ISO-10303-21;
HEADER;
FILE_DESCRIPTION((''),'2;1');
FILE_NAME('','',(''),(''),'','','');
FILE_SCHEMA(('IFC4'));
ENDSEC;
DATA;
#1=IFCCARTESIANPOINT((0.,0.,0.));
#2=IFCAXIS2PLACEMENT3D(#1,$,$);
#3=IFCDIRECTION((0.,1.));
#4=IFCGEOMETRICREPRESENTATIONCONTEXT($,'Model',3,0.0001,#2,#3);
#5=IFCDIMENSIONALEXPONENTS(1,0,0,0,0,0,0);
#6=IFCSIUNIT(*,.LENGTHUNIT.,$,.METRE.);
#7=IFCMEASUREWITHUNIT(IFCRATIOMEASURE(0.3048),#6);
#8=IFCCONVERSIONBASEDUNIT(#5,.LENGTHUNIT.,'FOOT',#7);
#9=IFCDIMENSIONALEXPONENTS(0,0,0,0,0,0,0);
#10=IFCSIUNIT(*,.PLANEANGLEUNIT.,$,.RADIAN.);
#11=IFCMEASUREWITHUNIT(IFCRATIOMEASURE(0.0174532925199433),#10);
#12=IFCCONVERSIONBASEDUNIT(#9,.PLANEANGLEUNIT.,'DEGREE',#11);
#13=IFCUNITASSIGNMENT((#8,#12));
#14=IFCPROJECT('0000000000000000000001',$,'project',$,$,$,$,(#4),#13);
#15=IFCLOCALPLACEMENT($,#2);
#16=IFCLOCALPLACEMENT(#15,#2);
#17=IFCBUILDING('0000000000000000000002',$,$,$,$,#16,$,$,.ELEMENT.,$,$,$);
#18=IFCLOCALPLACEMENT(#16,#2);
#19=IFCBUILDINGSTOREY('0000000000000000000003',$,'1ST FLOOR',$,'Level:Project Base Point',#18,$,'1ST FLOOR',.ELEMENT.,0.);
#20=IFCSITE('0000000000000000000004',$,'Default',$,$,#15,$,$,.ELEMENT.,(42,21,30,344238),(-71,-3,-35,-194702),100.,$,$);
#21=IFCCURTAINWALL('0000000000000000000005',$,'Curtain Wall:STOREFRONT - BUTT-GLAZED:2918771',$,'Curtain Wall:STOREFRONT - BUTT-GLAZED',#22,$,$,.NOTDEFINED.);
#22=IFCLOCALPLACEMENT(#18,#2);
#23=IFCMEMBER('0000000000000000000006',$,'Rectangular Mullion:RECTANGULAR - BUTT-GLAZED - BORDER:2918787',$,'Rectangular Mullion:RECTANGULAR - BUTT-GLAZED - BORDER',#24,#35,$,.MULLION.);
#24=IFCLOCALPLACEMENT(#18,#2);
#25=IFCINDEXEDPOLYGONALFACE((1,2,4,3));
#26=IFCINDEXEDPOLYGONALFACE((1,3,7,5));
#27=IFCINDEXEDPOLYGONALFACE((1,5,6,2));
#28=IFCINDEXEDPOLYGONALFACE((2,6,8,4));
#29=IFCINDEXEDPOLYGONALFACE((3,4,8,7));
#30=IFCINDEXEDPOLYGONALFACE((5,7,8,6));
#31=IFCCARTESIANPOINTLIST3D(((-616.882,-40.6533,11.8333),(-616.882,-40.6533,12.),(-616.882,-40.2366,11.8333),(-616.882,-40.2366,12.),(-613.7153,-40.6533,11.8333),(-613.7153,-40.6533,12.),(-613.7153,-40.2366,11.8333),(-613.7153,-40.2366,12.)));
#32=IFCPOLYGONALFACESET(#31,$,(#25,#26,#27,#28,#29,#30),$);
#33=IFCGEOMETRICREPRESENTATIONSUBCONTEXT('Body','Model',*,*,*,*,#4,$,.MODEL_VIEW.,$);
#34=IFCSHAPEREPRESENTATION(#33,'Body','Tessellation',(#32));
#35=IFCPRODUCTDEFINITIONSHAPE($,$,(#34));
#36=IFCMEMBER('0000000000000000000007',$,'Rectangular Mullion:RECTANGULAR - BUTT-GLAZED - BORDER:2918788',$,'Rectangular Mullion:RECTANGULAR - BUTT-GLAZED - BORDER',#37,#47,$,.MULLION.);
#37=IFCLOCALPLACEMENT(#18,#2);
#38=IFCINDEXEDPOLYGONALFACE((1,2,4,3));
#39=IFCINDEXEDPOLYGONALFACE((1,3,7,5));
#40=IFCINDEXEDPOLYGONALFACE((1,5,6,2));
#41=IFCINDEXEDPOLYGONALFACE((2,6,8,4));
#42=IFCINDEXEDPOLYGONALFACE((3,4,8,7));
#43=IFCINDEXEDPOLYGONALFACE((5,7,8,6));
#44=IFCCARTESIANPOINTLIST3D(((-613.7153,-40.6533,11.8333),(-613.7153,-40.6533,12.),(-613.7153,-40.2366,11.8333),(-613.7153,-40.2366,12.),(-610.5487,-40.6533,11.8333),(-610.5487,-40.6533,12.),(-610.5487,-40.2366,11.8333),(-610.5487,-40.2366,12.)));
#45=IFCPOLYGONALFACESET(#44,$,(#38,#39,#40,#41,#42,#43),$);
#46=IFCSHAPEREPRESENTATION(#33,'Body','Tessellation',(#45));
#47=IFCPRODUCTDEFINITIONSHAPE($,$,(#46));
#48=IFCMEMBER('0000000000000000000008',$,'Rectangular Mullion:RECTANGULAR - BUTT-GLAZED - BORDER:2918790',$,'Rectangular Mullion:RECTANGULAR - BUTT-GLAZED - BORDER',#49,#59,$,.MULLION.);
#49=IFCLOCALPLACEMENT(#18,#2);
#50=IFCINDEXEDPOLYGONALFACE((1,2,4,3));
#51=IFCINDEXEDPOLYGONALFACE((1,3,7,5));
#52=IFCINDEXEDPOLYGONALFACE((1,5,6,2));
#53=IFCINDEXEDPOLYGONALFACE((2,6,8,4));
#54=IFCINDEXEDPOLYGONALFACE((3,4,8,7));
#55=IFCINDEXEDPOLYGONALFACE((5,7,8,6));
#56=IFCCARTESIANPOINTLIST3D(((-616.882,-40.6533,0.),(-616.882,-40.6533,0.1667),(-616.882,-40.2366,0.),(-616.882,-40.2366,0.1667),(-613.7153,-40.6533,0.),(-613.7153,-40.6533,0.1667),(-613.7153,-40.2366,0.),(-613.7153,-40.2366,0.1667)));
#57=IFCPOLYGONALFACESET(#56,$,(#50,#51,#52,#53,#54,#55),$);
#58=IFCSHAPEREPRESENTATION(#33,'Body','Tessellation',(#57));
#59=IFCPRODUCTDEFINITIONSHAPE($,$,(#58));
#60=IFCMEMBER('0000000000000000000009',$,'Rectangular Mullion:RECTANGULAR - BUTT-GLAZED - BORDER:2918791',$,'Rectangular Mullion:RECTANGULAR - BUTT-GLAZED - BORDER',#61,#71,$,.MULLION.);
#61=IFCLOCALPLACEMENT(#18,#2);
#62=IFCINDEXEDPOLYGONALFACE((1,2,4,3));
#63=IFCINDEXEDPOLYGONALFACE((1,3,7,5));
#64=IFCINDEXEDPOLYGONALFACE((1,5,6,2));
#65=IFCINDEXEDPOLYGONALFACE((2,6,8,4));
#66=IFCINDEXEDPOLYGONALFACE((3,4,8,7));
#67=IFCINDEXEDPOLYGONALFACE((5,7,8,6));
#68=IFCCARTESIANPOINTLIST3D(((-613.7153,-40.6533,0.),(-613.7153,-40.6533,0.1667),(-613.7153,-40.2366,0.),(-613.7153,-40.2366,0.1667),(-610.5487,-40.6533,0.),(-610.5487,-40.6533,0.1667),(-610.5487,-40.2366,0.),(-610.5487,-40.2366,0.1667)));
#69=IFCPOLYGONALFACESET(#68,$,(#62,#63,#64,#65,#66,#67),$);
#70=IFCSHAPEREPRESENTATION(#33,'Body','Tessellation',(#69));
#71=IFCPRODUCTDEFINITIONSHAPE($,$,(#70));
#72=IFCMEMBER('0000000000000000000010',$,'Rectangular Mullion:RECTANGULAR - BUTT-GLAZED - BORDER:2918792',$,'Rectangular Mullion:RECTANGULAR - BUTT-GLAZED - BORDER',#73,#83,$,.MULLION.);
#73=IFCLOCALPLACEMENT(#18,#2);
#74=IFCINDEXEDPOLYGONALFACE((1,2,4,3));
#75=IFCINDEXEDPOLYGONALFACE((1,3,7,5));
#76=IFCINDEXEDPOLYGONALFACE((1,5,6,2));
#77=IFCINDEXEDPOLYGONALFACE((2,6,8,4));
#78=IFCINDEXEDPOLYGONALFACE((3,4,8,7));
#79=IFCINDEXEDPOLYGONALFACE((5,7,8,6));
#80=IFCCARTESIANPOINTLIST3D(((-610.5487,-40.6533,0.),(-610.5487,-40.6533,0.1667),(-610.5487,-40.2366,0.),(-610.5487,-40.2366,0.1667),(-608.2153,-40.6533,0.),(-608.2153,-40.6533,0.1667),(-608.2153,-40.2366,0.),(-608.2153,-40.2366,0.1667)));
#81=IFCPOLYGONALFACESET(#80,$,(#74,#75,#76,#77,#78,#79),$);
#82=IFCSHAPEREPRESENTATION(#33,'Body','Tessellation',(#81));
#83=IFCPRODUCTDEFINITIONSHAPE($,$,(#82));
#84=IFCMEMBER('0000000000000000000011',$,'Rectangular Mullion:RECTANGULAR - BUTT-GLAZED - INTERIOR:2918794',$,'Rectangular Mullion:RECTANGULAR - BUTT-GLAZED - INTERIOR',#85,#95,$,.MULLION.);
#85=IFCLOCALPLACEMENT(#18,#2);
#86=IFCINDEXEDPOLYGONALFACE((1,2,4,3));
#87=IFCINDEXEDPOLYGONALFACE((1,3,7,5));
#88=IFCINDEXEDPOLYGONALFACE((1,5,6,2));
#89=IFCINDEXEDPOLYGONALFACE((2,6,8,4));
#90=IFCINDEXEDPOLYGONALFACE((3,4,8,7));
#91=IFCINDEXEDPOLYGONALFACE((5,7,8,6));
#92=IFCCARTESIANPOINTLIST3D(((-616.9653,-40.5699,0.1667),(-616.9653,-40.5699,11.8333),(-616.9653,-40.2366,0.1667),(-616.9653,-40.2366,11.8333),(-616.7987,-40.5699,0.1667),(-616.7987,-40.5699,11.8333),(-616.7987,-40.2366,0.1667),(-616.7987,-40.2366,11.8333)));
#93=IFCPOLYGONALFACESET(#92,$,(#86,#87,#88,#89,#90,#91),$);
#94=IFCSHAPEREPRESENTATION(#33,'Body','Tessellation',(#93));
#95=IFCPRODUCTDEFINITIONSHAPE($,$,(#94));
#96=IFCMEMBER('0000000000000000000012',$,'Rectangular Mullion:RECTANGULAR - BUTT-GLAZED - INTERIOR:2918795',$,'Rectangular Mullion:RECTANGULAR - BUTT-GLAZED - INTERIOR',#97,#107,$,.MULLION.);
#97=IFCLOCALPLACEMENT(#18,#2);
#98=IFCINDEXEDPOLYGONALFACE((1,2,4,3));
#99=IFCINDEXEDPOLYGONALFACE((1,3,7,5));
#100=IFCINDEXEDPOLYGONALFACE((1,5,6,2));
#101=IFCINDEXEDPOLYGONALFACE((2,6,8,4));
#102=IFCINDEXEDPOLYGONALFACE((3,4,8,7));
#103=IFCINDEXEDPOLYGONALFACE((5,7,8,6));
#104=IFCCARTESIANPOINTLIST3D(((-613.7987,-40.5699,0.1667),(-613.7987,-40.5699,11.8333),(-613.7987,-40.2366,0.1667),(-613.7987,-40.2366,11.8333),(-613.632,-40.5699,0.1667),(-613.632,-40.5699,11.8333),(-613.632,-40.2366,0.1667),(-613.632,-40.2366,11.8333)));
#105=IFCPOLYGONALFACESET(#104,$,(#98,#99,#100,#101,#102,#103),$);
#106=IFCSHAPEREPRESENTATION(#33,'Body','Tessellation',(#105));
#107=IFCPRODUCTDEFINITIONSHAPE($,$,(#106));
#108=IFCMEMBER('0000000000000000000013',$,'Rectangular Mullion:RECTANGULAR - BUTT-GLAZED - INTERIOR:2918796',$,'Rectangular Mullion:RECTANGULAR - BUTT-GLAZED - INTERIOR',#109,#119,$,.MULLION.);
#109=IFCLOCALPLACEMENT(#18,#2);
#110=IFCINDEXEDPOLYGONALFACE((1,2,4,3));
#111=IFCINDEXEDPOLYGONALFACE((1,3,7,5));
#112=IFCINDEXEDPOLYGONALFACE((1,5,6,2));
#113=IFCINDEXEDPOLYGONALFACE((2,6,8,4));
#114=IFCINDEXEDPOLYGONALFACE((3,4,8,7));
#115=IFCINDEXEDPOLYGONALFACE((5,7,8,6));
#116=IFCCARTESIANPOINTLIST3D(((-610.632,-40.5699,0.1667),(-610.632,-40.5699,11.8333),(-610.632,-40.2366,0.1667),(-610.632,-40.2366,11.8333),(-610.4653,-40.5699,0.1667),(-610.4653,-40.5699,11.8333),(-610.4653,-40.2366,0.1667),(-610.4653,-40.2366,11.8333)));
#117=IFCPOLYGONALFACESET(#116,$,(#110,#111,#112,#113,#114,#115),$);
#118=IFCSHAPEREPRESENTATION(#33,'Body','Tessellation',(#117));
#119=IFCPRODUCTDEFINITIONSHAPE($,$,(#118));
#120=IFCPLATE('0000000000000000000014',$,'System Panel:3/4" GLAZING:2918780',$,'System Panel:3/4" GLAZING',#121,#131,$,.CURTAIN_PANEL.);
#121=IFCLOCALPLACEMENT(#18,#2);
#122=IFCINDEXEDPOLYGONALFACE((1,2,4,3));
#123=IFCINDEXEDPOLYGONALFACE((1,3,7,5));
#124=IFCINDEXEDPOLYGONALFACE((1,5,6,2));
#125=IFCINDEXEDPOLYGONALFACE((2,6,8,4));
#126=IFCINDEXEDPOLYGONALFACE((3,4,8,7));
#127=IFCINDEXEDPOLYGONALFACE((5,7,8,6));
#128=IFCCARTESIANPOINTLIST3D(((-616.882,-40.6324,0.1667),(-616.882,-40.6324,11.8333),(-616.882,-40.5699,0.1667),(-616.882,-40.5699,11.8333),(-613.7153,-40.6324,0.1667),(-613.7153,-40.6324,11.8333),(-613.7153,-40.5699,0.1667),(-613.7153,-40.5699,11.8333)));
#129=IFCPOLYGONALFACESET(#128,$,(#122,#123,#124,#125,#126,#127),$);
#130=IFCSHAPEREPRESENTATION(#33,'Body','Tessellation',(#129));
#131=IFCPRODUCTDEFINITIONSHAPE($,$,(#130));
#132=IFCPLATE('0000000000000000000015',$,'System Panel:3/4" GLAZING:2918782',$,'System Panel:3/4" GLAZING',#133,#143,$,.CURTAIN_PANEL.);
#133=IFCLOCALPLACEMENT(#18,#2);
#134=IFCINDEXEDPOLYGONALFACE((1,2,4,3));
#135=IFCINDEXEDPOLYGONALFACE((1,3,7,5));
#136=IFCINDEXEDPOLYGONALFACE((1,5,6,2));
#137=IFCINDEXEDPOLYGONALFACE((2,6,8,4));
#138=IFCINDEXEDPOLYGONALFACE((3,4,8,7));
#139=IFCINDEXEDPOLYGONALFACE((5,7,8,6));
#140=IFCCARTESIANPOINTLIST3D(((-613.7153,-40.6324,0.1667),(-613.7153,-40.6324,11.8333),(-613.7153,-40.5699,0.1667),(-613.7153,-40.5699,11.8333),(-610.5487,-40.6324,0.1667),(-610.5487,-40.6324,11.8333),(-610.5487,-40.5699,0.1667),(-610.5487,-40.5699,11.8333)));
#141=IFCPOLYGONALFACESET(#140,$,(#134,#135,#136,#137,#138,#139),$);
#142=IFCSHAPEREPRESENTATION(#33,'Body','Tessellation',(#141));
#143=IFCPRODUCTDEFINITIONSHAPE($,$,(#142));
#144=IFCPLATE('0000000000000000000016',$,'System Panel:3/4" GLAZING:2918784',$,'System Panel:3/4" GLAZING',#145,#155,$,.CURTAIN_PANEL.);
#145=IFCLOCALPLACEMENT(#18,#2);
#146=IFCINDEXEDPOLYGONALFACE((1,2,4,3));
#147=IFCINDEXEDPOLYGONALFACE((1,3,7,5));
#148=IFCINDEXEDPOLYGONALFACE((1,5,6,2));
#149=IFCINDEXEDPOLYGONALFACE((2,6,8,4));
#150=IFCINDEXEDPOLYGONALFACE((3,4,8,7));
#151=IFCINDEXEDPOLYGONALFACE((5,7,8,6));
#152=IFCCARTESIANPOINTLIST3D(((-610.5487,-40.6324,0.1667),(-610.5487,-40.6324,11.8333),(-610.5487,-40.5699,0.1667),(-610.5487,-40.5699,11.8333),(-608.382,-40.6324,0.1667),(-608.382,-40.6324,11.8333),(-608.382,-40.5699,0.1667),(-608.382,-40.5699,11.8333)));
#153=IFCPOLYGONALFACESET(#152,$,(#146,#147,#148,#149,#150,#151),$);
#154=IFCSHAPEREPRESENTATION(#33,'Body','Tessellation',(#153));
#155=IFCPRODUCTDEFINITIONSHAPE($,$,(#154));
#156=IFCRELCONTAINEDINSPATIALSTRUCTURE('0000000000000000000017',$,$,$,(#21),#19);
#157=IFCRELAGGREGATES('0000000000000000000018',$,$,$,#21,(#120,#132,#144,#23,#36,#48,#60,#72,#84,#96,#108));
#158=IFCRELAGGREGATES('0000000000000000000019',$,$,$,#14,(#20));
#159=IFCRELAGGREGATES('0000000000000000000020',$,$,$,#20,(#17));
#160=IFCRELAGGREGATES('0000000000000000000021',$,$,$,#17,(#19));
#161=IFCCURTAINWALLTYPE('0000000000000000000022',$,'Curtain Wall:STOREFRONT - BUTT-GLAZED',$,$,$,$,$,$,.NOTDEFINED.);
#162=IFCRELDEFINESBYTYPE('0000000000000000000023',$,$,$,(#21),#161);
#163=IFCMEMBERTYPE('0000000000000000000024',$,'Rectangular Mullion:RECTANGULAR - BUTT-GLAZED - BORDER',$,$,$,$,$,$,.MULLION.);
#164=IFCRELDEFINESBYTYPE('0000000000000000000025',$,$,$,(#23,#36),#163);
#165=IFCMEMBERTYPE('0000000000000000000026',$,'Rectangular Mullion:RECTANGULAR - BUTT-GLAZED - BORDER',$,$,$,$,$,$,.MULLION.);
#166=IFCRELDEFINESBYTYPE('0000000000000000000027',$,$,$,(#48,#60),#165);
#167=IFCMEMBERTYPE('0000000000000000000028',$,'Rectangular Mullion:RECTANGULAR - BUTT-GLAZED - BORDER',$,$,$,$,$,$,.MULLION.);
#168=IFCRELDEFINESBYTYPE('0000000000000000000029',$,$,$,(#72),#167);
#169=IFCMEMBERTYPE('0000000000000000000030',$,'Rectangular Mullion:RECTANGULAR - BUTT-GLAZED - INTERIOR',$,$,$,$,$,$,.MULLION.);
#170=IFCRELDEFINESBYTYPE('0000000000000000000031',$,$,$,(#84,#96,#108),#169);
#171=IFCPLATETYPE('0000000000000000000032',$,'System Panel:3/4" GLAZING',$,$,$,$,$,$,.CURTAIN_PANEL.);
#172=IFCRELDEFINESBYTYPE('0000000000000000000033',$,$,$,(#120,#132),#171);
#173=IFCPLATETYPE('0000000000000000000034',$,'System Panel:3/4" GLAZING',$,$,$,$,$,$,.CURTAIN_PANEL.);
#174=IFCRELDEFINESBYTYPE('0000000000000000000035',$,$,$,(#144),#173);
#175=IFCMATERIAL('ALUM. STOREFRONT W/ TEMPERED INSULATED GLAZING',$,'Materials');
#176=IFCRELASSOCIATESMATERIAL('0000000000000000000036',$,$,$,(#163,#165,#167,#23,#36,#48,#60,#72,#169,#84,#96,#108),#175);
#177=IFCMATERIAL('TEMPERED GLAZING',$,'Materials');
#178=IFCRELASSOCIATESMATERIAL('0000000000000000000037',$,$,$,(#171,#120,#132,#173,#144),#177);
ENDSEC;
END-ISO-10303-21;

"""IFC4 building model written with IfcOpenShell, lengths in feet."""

from ifc_helpers import new_model, entity, si_unit, converted_unit, direction, frame, frame_2d, origin, origin_2d_with_axis, place, context, subcontext, project, spatial, rectangle, extrude, source, transform, mapped, material, material_profile, profile_set, profile_usage, type_object, type_shapes, element, aggregate, save


model = new_model("IFC4")

# Units and contexts
model_context = context("Model", 3, precision=0.0001, world=origin(), true_north=direction((0.0, 1.0)))
body_context = subcontext(model_context, "Body", "Model", "MODEL_VIEW")
ifc_project = project(units=[converted_unit("LENGTHUNIT", "FOOT", entity("IfcRatioMeasure", 0.3048), si_unit("LENGTHUNIT", "METRE"), dimensions=[1, 0, 0, 0, 0, 0, 0]), converted_unit("PLANEANGLEUNIT", "DEGREE", entity("IfcRatioMeasure", 0.0174532925199433), si_unit("PLANEANGLEUNIT", "RADIAN"), dimensions=[0, 0, 0, 0, 0, 0, 0])], contexts=[model_context])

# Site, building, storey
site_placement = place(None, origin())
site = spatial("IfcSite", under=ifc_project, at=site_placement, Name="Default", CompositionType="ELEMENT", RefLatitude=(42, 21, 30, 344238), RefLongitude=(-71, -3, -35, -194702), RefElevation=100.0)
building_placement = place(site_placement, origin())
building = spatial("IfcBuilding", under=site, at=building_placement, CompositionType="ELEMENT")
storey_placement = place(building_placement, origin())
storey = spatial("IfcBuildingStorey", under=building, at=storey_placement, Name="1ST FLOOR", ObjectType="Level:Project Base Point", LongName="1ST FLOOR", CompositionType="ELEMENT", Elevation=0.0)

# Shared definitions
ifc_material_1 = material(Name="ALUM. STOREFRONT W/ TEMPERED INSULATED GLAZING", Category="Materials")

# Curtain wall, members, plates
curtain_wall_type_1 = type_object("IfcCurtainWallType", Name="Curtain Wall:STOREFRONT - BUTT-GLAZED", PredefinedType="NOTDEFINED")
curtain_wall_1_placement = place(storey_placement, origin())
curtain_wall_1 = element("IfcCurtainWall", 1, at=curtain_wall_1_placement, inside=storey, type_object=curtain_wall_type_1, Name="Curtain Wall:STOREFRONT - BUTT-GLAZED:2918771", ObjectType="Curtain Wall:STOREFRONT - BUTT-GLAZED", PredefinedType="NOTDEFINED")
ifc_material_profile_1 = material_profile(ifc_material_1, rectangle(XDim=0.4167, YDim=0.1667, at=frame_2d((0.0, 0.0), x_axis=(1.0, 0.0))), Name="RECTANGULAR - BUTT-GLAZED - BORDER")
ifc_profile_set_1 = profile_set([ifc_material_profile_1], Name="RECTANGULAR - BUTT-GLAZED - BORDER")
member_type_1 = type_object("IfcMemberType", Name="Rectangular Mullion:RECTANGULAR - BUTT-GLAZED - BORDER", PredefinedType="MULLION", material=ifc_profile_set_1)
shared_shape_1 = source(origin(), body_context, "Body", "SweptSolid", [
    extrude(rectangle(XDim=0.4167, YDim=0.1667, at=frame_2d((0.0, 0.0), x_axis=(1.0, 0.0))), frame((-0.0833, -0.1562, -3.1667), z_axis=(0.0, 0.0, 1.0), x_axis=(0.0, -1.0, 0.0)), (0.0, 0.0, 1.0), 3.1667),
])
type_shapes(member_type_1, [shared_shape_1])
ifc_profile_usage_1 = profile_usage(ifc_profile_set_1)
member_1_placement = place(storey_placement, frame((-613.7153, -40.6012, 12.0), z_axis=(1.0, 0.0, 0.0), x_axis=(0.0, 0.0, 1.0)))
member_1 = element("IfcMember", 2, at=member_1_placement, type_object=member_type_1, material=ifc_profile_usage_1, Name="Rectangular Mullion:RECTANGULAR - BUTT-GLAZED - BORDER:2918787", ObjectType="Rectangular Mullion:RECTANGULAR - BUTT-GLAZED - BORDER", PredefinedType="MULLION", context=body_context, shape_type="MappedRepresentation", body=[
    mapped(shared_shape_1, transform((0.0, 0.0, 0.0), scale=1.0)),
])
ifc_profile_usage_2 = profile_usage(ifc_profile_set_1)
member_2_placement = place(storey_placement, frame((-610.5487, -40.6012, 12.0), z_axis=(1.0, 0.0, 0.0), x_axis=(0.0, 0.0, 1.0)))
member_2 = element("IfcMember", 3, at=member_2_placement, type_object=member_type_1, material=ifc_profile_usage_2, Name="Rectangular Mullion:RECTANGULAR - BUTT-GLAZED - BORDER:2918788", ObjectType="Rectangular Mullion:RECTANGULAR - BUTT-GLAZED - BORDER", PredefinedType="MULLION", context=body_context, shape_type="MappedRepresentation", body=[
    mapped(shared_shape_1, transform((0.0, 0.0, 0.0), scale=1.0)),
])
ifc_profile_usage_3 = profile_usage(ifc_profile_set_1)
member_type_2 = type_object("IfcMemberType", Name="Rectangular Mullion:RECTANGULAR - BUTT-GLAZED - BORDER", PredefinedType="MULLION", material=ifc_profile_set_1)
shared_shape_2 = source(origin(), body_context, "Body", "SweptSolid", [
    extrude(rectangle(XDim=0.4167, YDim=0.1667, at=frame_2d((0.0, 0.0), x_axis=(1.0, 0.0))), frame((-0.0833, -0.1562, -3.1667), z_axis=(0.0, 0.0, 1.0), x_axis=(0.0, -1.0, 0.0)), (0.0, 0.0, 1.0), 3.1667),
])
type_shapes(member_type_2, [shared_shape_2])
member_3_placement = place(storey_placement, frame((-616.882, -40.6012, 0.0), z_axis=(-1.0, 0.0, 0.0), x_axis=(0.0, 0.0, -1.0)))
member_3 = element("IfcMember", 4, at=member_3_placement, type_object=member_type_2, material=ifc_profile_usage_3, Name="Rectangular Mullion:RECTANGULAR - BUTT-GLAZED - BORDER:2918790", ObjectType="Rectangular Mullion:RECTANGULAR - BUTT-GLAZED - BORDER", PredefinedType="MULLION", context=body_context, shape_type="MappedRepresentation", body=[
    mapped(shared_shape_2, transform((0.0, 0.0, 0.0), scale=1.0)),
])
ifc_profile_usage_4 = profile_usage(ifc_profile_set_1)
member_4_placement = place(storey_placement, frame((-613.7153, -40.6012, 0.0), z_axis=(-1.0, 0.0, 0.0), x_axis=(0.0, 0.0, -1.0)))
member_4 = element("IfcMember", 5, at=member_4_placement, type_object=member_type_2, material=ifc_profile_usage_4, Name="Rectangular Mullion:RECTANGULAR - BUTT-GLAZED - BORDER:2918791", ObjectType="Rectangular Mullion:RECTANGULAR - BUTT-GLAZED - BORDER", PredefinedType="MULLION", context=body_context, shape_type="MappedRepresentation", body=[
    mapped(shared_shape_2, transform((0.0, 0.0, 0.0), scale=1.0)),
])
ifc_profile_usage_5 = profile_usage(ifc_profile_set_1)
member_type_3 = type_object("IfcMemberType", Name="Rectangular Mullion:RECTANGULAR - BUTT-GLAZED - BORDER", PredefinedType="MULLION", material=ifc_profile_set_1)
shared_shape_3 = source(origin(), body_context, "Body", "SweptSolid", [
    extrude(rectangle(XDim=0.4167, YDim=0.1667, at=frame_2d((0.0, 0.0), x_axis=(1.0, 0.0))), frame((-0.0833, -0.1562, -2.3333), z_axis=(0.0, 0.0, 1.0), x_axis=(0.0, -1.0, 0.0)), (0.0, 0.0, 1.0), 2.3333),
])
type_shapes(member_type_3, [shared_shape_3])
member_5_placement = place(storey_placement, frame((-610.5487, -40.6012, 0.0), z_axis=(-1.0, 0.0, 0.0), x_axis=(0.0, 0.0, -1.0)))
member_5 = element("IfcMember", 6, at=member_5_placement, type_object=member_type_3, material=ifc_profile_usage_5, Name="Rectangular Mullion:RECTANGULAR - BUTT-GLAZED - BORDER:2918792", ObjectType="Rectangular Mullion:RECTANGULAR - BUTT-GLAZED - BORDER", PredefinedType="MULLION", context=body_context, shape_type="MappedRepresentation", body=[
    mapped(shared_shape_3, transform((0.0, 0.0, 0.0), scale=1.0)),
])
ifc_material_profile_2 = material_profile(ifc_material_1, rectangle(XDim=0.3333, YDim=0.1667, at=origin_2d_with_axis()), Name="RECTANGULAR - BUTT-GLAZED - INTERIOR")
ifc_profile_set_2 = profile_set([ifc_material_profile_2], Name="RECTANGULAR - BUTT-GLAZED - INTERIOR")
ifc_profile_usage_6 = profile_usage(ifc_profile_set_2)
member_type_4 = type_object("IfcMemberType", Name="Rectangular Mullion:RECTANGULAR - BUTT-GLAZED - INTERIOR", PredefinedType="MULLION", material=ifc_profile_set_2)
shared_shape_4 = source(origin(), body_context, "Body", "SweptSolid", [
    extrude(rectangle(XDim=0.3333, YDim=0.1667, at=origin_2d_with_axis()), frame((0.0, -0.1979, -11.6667), z_axis=(0.0, 0.0, 1.0), x_axis=(0.0, -1.0, 0.0)), (0.0, 0.0, 1.0), 11.6667),
])
type_shapes(member_type_4, [shared_shape_4])
member_6_placement = place(storey_placement, frame((-616.882, -40.6012, 0.1667), z_axis=(0.0, 0.0, -1.0), x_axis=(1.0, 0.0, 0.0)))
member_6 = element("IfcMember", 7, at=member_6_placement, type_object=member_type_4, material=ifc_profile_usage_6, Name="Rectangular Mullion:RECTANGULAR - BUTT-GLAZED - INTERIOR:2918794", ObjectType="Rectangular Mullion:RECTANGULAR - BUTT-GLAZED - INTERIOR", PredefinedType="MULLION", context=body_context, shape_type="MappedRepresentation", body=[
    mapped(shared_shape_4, transform((0.0, 0.0, 0.0), scale=1.0)),
])
ifc_profile_usage_7 = profile_usage(ifc_profile_set_2)
member_7_placement = place(storey_placement, frame((-613.7153, -40.6012, 0.1667), z_axis=(0.0, 0.0, -1.0), x_axis=(1.0, 0.0, 0.0)))
member_7 = element("IfcMember", 8, at=member_7_placement, type_object=member_type_4, material=ifc_profile_usage_7, Name="Rectangular Mullion:RECTANGULAR - BUTT-GLAZED - INTERIOR:2918795", ObjectType="Rectangular Mullion:RECTANGULAR - BUTT-GLAZED - INTERIOR", PredefinedType="MULLION", context=body_context, shape_type="MappedRepresentation", body=[
    mapped(shared_shape_4, transform((0.0, 0.0, 0.0), scale=1.0)),
])
ifc_profile_usage_8 = profile_usage(ifc_profile_set_2)
member_8_placement = place(storey_placement, frame((-610.5487, -40.6012, 0.1667), z_axis=(0.0, 0.0, -1.0), x_axis=(1.0, 0.0, 0.0)))
member_8 = element("IfcMember", 9, at=member_8_placement, type_object=member_type_4, material=ifc_profile_usage_8, Name="Rectangular Mullion:RECTANGULAR - BUTT-GLAZED - INTERIOR:2918796", ObjectType="Rectangular Mullion:RECTANGULAR - BUTT-GLAZED - INTERIOR", PredefinedType="MULLION", context=body_context, shape_type="MappedRepresentation", body=[
    mapped(shared_shape_4, transform((0.0, 0.0, 0.0), scale=1.0)),
])
ifc_material_2 = material(Name="TEMPERED GLAZING", Category="Materials")
plate_type_1 = type_object("IfcPlateType", Name="System Panel:3/4\" GLAZING", PredefinedType="CURTAIN_PANEL", material=ifc_material_2)
shared_shape_5 = source(origin(), body_context, "Body", "SweptSolid", [
    extrude(rectangle(XDim=0.0625, YDim=3.1667, at=origin_2d_with_axis()), frame((0.0, 0.0, 0.0), z_axis=(0.0, 0.0, 1.0), x_axis=(0.0, 1.0, 0.0)), (0.0, 0.0, 1.0), 11.6667),
])
type_shapes(plate_type_1, [shared_shape_5])
plate_1_placement = place(curtain_wall_1_placement, frame((-615.2987, -40.6012, 0.1667)))
plate_1 = element("IfcPlate", 10, at=plate_1_placement, type_object=plate_type_1, material=ifc_material_2, Name="System Panel:3/4\" GLAZING:2918780", ObjectType="System Panel:3/4\" GLAZING", PredefinedType="CURTAIN_PANEL", context=body_context, shape_type="MappedRepresentation", body=[
    mapped(shared_shape_5, transform((0.0, 0.0, 0.0), scale=1.0)),
])
plate_2_placement = place(curtain_wall_1_placement, frame((-612.132, -40.6012, 0.1667)))
plate_2 = element("IfcPlate", 11, at=plate_2_placement, type_object=plate_type_1, material=ifc_material_2, Name="System Panel:3/4\" GLAZING:2918782", ObjectType="System Panel:3/4\" GLAZING", PredefinedType="CURTAIN_PANEL", context=body_context, shape_type="MappedRepresentation", body=[
    mapped(shared_shape_5, transform((0.0, 0.0, 0.0), scale=1.0)),
])
plate_type_2 = type_object("IfcPlateType", Name="System Panel:3/4\" GLAZING", PredefinedType="CURTAIN_PANEL", material=ifc_material_2)
shared_shape_6 = source(origin(), body_context, "Body", "SweptSolid", [
    extrude(rectangle(XDim=0.0625, YDim=2.1667, at=origin_2d_with_axis()), frame((0.0, 0.0, 0.0), z_axis=(0.0, 0.0, 1.0), x_axis=(0.0, 1.0, 0.0)), (0.0, 0.0, 1.0), 11.6667),
])
type_shapes(plate_type_2, [shared_shape_6])
plate_3_placement = place(curtain_wall_1_placement, frame((-609.4653, -40.6012, 0.1667)))
plate_3 = element("IfcPlate", 12, at=plate_3_placement, type_object=plate_type_2, material=ifc_material_2, Name="System Panel:3/4\" GLAZING:2918784", ObjectType="System Panel:3/4\" GLAZING", PredefinedType="CURTAIN_PANEL", context=body_context, shape_type="MappedRepresentation", body=[
    mapped(shared_shape_6, transform((0.0, 0.0, 0.0), scale=1.0)),
])
aggregate(curtain_wall_1, [plate_1, plate_2, plate_3, member_1, member_2, member_3, member_4, member_5, member_6, member_7, member_8])

save(model, "model.ifc")
